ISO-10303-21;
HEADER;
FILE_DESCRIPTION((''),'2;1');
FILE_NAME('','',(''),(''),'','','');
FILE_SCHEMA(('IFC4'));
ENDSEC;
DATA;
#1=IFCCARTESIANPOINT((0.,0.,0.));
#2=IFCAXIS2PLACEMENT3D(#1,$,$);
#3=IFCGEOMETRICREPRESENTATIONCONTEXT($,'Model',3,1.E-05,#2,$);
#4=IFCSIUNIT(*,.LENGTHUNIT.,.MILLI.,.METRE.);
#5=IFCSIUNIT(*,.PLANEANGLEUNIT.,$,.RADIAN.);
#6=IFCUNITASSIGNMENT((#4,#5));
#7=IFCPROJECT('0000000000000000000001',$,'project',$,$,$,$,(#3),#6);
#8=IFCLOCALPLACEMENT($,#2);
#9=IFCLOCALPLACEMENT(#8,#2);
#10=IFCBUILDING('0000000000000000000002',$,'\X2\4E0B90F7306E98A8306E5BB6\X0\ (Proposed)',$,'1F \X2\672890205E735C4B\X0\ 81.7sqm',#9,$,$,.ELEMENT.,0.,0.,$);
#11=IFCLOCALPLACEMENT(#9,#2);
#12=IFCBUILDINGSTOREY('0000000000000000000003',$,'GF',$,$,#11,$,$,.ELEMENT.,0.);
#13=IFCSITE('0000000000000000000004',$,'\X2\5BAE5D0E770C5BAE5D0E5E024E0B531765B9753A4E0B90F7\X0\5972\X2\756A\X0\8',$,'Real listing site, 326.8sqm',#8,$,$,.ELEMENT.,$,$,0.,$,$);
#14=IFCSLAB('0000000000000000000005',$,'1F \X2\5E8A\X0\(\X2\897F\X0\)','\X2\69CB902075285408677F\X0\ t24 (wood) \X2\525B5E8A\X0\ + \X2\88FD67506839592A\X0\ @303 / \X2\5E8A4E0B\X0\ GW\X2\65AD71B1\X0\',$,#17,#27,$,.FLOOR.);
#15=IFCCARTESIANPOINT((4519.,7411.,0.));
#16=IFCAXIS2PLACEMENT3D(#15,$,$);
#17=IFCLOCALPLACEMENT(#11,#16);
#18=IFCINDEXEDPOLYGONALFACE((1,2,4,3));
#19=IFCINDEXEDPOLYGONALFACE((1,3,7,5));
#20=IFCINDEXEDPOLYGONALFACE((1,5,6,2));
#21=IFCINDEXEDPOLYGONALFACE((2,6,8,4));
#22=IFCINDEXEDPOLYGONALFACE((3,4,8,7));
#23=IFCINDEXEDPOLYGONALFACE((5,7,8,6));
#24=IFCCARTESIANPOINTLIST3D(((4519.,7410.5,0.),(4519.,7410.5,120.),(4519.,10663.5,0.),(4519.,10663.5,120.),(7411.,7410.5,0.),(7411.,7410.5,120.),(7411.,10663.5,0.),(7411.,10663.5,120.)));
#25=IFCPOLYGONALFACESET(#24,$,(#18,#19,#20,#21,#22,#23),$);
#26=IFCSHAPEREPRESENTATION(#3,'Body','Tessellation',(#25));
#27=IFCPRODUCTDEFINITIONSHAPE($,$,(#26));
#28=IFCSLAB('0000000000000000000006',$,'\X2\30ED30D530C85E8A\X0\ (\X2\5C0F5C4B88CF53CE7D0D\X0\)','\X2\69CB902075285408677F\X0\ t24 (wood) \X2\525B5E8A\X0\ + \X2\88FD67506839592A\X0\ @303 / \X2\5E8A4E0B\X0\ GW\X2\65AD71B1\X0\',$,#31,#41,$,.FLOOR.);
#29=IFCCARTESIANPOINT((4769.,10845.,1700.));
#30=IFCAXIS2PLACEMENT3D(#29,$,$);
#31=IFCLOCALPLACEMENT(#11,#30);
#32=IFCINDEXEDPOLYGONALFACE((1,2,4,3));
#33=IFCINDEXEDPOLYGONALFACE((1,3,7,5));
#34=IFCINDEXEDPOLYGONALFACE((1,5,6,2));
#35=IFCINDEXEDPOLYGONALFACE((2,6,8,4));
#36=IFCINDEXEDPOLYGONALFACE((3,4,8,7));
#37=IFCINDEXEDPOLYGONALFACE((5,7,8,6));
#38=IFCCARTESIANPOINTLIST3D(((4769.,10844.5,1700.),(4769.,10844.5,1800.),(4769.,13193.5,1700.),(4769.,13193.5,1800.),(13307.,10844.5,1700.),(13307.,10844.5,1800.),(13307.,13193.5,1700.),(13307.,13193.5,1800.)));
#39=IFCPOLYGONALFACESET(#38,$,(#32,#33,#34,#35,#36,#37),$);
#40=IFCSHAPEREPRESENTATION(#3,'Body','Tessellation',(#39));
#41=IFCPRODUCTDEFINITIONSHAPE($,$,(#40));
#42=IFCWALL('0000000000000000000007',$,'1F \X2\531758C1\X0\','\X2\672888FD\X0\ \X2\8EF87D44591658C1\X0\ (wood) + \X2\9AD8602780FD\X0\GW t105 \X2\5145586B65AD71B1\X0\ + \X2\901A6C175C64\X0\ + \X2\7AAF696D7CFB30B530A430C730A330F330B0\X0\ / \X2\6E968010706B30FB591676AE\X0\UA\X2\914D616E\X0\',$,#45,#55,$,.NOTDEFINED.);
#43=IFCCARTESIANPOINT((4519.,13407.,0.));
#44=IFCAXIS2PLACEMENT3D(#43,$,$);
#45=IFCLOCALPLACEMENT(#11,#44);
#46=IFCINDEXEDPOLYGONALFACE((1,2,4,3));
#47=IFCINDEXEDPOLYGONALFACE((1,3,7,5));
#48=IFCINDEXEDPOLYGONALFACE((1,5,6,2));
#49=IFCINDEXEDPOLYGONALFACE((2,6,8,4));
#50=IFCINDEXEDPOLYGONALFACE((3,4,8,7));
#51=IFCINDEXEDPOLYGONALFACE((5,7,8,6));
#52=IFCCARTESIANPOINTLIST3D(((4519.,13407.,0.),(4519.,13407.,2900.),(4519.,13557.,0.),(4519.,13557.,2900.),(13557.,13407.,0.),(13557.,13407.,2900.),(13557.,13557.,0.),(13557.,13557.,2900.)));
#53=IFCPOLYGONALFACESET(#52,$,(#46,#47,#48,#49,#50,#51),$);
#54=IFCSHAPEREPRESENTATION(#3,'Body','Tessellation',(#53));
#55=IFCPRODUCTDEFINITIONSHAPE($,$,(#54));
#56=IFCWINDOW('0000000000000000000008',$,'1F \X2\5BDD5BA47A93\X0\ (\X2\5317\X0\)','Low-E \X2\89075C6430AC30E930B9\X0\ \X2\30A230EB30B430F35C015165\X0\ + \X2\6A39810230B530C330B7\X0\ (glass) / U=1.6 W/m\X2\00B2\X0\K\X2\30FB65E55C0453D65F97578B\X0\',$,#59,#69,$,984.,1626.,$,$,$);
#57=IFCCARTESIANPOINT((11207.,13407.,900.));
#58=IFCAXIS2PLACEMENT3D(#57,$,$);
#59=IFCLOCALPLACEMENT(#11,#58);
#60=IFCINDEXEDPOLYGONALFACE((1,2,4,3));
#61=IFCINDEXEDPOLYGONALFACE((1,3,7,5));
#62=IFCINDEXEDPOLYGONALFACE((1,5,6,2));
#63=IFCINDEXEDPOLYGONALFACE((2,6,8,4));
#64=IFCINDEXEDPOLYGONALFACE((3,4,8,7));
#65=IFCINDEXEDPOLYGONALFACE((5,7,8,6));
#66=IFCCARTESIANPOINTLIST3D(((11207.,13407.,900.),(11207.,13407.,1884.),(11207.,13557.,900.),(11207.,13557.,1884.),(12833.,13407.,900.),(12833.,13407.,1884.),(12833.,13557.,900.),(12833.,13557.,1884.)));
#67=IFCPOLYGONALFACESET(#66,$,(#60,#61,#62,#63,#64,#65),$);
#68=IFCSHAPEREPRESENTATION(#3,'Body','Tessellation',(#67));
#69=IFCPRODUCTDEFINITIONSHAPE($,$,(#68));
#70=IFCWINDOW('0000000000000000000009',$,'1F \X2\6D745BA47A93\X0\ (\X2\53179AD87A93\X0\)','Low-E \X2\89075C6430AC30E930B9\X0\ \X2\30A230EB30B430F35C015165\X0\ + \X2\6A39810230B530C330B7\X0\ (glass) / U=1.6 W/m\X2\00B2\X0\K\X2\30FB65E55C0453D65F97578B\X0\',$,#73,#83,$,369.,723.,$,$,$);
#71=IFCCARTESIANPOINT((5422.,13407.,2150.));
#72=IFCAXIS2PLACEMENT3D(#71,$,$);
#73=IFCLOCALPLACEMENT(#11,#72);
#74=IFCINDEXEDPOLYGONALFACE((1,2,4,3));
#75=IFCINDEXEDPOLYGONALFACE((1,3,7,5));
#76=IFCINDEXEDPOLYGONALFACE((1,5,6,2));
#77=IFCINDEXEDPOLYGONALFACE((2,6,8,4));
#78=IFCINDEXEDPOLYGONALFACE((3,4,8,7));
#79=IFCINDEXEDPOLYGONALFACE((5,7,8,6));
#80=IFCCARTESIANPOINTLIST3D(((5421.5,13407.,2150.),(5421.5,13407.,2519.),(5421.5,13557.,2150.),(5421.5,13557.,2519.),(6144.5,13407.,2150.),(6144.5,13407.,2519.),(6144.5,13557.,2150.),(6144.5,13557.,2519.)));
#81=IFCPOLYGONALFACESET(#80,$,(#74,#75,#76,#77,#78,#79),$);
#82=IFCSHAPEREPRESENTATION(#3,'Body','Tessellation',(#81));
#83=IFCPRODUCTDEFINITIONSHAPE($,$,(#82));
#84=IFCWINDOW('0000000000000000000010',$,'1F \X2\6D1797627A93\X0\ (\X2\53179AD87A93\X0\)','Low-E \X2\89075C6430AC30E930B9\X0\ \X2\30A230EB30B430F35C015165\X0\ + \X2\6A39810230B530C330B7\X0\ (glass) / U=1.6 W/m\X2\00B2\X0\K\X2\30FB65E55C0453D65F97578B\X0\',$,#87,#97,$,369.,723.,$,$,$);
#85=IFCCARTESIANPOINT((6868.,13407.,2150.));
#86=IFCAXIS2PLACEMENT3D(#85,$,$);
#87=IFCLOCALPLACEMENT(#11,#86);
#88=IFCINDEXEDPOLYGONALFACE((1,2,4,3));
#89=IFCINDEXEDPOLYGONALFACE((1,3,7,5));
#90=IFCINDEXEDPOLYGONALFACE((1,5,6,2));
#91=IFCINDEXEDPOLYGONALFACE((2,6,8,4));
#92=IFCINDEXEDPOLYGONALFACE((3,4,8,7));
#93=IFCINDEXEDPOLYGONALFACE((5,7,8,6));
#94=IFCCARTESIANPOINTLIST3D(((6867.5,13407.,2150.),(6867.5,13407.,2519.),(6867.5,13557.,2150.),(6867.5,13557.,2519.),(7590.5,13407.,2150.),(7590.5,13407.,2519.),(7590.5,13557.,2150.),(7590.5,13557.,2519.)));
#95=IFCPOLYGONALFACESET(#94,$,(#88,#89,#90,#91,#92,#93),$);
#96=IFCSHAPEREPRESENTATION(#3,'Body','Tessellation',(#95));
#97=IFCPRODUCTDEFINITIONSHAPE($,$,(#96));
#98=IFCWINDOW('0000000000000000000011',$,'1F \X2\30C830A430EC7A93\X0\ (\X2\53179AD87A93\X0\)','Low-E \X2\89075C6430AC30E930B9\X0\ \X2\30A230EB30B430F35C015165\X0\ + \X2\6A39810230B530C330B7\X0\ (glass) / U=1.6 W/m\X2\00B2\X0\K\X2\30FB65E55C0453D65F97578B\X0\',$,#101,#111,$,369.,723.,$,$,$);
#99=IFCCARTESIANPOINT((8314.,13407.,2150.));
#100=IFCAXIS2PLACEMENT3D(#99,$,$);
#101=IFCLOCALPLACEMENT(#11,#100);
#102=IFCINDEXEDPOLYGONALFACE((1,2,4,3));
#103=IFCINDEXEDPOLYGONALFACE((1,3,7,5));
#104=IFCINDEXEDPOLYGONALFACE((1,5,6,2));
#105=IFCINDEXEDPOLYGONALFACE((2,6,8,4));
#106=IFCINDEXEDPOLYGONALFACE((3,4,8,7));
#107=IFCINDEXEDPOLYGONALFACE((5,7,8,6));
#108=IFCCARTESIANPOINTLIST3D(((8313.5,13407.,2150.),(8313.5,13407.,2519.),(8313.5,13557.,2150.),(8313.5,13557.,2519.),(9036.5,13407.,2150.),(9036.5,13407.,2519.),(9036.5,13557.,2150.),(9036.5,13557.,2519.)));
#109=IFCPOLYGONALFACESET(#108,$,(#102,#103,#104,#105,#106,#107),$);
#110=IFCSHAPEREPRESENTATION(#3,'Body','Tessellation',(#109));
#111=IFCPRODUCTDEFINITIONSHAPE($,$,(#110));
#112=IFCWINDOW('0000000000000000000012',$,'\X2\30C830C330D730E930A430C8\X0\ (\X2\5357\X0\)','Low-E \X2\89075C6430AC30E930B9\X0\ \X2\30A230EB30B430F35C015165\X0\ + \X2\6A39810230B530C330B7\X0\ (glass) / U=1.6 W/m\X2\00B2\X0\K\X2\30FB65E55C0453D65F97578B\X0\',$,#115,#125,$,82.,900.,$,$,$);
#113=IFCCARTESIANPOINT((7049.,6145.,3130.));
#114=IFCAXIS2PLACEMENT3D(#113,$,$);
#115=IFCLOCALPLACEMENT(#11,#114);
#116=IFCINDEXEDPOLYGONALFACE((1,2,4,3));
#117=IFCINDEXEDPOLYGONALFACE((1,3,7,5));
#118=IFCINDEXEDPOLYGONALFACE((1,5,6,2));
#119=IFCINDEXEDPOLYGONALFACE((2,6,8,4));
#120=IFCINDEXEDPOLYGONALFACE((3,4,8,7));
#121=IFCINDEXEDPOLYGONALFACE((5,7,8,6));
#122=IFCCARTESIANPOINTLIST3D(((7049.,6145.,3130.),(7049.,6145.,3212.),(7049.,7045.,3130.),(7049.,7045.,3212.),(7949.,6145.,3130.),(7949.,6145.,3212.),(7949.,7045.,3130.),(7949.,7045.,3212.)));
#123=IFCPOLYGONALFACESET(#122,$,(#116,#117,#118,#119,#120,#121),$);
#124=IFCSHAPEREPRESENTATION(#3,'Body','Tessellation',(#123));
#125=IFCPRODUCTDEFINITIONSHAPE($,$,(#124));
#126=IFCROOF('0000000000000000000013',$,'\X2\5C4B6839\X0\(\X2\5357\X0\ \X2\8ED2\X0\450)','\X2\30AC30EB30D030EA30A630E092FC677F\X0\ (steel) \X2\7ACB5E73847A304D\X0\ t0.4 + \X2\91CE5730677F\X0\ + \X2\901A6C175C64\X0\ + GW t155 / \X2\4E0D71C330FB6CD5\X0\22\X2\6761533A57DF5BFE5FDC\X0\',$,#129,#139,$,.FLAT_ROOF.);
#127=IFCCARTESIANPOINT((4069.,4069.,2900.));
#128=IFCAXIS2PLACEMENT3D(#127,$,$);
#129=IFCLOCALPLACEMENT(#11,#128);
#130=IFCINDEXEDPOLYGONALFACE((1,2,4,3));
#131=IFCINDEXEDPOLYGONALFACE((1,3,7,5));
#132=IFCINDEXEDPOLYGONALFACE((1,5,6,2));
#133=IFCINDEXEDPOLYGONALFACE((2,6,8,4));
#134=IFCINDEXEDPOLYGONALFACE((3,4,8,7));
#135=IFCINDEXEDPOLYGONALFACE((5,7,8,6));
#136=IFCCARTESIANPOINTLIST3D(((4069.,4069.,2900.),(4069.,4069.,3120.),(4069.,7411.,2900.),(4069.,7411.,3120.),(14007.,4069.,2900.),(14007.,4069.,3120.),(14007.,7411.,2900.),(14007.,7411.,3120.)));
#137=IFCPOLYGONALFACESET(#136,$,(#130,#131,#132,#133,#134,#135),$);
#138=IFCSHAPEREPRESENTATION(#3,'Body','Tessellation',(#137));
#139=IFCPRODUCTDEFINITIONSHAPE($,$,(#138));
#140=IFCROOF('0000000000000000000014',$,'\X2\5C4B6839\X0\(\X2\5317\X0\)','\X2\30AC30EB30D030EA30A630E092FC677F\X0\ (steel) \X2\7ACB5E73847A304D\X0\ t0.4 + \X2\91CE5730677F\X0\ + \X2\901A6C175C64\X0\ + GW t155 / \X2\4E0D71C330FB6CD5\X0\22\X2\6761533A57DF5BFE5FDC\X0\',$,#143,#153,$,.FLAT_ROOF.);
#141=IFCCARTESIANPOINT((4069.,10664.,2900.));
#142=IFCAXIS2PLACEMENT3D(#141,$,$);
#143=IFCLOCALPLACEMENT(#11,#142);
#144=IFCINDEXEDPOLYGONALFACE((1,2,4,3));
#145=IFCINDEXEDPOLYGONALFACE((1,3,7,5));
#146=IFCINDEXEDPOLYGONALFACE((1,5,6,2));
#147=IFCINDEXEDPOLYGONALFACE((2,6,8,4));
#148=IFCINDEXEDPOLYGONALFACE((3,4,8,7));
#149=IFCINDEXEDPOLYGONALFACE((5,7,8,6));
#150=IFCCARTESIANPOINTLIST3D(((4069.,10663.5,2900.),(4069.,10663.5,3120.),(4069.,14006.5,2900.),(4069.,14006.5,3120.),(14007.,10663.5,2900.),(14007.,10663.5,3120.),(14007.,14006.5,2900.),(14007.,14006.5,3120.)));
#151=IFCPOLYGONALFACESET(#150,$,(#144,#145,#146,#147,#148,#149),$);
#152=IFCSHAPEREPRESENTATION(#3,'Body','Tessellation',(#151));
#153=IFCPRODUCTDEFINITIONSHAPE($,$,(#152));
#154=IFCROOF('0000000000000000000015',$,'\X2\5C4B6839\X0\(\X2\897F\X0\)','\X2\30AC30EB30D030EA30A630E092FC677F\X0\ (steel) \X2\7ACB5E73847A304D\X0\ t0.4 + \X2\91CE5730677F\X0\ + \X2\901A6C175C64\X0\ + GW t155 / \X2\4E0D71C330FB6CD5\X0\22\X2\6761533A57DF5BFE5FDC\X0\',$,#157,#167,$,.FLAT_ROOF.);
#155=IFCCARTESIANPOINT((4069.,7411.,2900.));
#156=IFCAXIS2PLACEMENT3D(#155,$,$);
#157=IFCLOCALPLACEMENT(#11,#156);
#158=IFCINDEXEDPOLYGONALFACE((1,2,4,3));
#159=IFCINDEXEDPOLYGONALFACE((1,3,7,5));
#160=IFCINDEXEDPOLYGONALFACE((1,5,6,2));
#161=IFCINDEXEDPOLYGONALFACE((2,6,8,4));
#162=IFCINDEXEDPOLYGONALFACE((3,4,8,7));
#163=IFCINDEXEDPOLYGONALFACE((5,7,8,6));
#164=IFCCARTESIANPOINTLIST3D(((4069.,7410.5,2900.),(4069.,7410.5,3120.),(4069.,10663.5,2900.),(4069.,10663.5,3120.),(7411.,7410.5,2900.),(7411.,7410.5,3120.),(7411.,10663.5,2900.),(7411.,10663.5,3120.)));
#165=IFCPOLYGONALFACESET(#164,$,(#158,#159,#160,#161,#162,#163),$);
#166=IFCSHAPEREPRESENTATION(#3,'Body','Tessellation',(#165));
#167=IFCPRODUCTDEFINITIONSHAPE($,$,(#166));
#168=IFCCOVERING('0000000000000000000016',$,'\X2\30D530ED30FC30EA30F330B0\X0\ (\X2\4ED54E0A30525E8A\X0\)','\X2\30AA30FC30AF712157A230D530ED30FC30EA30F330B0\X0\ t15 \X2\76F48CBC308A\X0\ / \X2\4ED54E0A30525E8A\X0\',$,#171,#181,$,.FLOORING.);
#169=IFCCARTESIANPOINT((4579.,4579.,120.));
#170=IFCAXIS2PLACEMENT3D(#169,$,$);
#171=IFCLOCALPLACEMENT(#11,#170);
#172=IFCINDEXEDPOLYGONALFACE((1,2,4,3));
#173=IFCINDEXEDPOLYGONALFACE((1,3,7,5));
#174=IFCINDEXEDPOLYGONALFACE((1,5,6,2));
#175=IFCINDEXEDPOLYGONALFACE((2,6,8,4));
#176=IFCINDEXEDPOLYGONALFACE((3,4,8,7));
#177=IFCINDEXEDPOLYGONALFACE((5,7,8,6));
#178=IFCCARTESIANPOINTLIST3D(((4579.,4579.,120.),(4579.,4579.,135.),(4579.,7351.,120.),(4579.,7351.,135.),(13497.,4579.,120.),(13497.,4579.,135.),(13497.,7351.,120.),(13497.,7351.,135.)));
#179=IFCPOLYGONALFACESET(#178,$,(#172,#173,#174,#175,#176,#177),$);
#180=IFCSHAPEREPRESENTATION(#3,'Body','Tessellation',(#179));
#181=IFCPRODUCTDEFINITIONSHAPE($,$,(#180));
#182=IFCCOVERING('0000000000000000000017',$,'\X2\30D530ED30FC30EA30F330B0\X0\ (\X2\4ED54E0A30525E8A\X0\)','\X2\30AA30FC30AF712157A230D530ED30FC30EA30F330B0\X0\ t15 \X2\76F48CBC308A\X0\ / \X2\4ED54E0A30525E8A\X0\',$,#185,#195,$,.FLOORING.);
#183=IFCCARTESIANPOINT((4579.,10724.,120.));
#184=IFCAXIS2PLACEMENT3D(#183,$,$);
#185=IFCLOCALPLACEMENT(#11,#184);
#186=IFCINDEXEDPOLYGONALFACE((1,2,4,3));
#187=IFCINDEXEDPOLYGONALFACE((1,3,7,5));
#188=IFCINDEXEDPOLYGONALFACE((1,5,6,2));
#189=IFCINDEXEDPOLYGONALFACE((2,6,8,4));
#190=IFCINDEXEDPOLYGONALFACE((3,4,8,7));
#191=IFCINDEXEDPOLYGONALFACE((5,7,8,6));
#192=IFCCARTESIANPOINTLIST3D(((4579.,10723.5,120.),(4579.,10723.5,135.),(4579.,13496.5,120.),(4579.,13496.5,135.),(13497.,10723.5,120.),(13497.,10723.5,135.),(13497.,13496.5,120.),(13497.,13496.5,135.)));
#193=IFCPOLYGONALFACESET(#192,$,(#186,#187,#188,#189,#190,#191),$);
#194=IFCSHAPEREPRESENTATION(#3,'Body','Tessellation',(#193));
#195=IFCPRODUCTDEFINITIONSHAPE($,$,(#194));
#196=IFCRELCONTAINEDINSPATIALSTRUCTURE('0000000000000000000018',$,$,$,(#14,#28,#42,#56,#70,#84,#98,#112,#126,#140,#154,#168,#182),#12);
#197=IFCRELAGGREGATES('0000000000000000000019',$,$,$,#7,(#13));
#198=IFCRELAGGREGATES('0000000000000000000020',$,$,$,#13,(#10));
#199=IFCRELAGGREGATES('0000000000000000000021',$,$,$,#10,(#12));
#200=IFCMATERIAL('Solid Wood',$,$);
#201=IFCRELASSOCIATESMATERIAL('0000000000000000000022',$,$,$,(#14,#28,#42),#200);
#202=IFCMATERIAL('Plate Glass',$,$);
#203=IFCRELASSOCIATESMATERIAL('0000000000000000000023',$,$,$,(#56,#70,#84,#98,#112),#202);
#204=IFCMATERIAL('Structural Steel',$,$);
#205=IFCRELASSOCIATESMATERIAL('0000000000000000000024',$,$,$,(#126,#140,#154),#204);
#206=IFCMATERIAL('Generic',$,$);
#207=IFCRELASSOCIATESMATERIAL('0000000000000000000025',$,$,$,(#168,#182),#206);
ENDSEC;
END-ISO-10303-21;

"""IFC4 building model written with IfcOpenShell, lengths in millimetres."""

from ifc_helpers import new_model, si_unit, frame, frame_2d, origin, place, context, project, spatial, rectangle, extrude, material, element, fill, save


model = new_model("IFC4")

# Units and contexts
model_context = context("Model", 3, precision=1e-05, world=origin())
ifc_project = project(units=[si_unit("LENGTHUNIT", "METRE", prefix="MILLI"), si_unit("PLANEANGLEUNIT", "RADIAN")], contexts=[model_context])

# Site, building, storey
site_placement = place(None, origin())
site = spatial("IfcSite", under=ifc_project, at=site_placement, Name="宮崎県宮崎市下北方町下郷5972番8", ObjectType="Real listing site, 326.8sqm", CompositionType="ELEMENT", RefElevation=0.0)
building_placement = place(site_placement, origin())
building = spatial("IfcBuilding", under=site, at=building_placement, Name="下郷の風の家 (Proposed)", ObjectType="1F 木造平屋 81.7sqm", CompositionType="ELEMENT", ElevationOfRefHeight=0.0, ElevationOfTerrain=0.0)
storey_placement = place(building_placement, origin())
storey = spatial("IfcBuildingStorey", under=building, at=storey_placement, Name="GF", CompositionType="ELEMENT", Elevation=0.0)

# Slabs
ifc_material_1 = material(Name="Solid Wood")
slab_1_placement = place(storey_placement, frame((4519.0, 7411.0, 0.0)))
element("IfcSlab", 1, at=slab_1_placement, inside=storey, material=ifc_material_1, Name="1F 床(西)", Description="構造用合板 t24 (wood) 剛床 + 製材根太 @303 / 床下 GW断熱", PredefinedType="FLOOR", context=model_context, shape_type="SweptSolid", body=[
    extrude(rectangle(XDim=2892.0, YDim=3253.0, at=frame_2d((1446.0, 1626.0))), frame((4519.0, 7411.0, 0.0)), (0.0, 0.0, 1.0), 120.0),
])
slab_2_placement = place(storey_placement, frame((4769.0, 10845.0, 1700.0)))
element("IfcSlab", 2, at=slab_2_placement, inside=storey, material=ifc_material_1, Name="ロフト床 (小屋裏収納)", Description="構造用合板 t24 (wood) 剛床 + 製材根太 @303 / 床下 GW断熱", PredefinedType="FLOOR", context=model_context, shape_type="SweptSolid", body=[
    extrude(rectangle(XDim=8538.0, YDim=2349.0, at=frame_2d((4269.0, 1174.0))), frame((4769.0, 10845.0, 1700.0)), (0.0, 0.0, 1.0), 100.0),
])

# Shared definitions
ifc_material_2 = material(Name="Plate Glass")

# Wall, openings, windows
wall_1_placement = place(storey_placement, frame((4519.0, 13407.0, 0.0)))
wall_1 = element("IfcWall", 3, at=wall_1_placement, inside=storey, material=ifc_material_1, Name="1F 北壁", Description="木製 軸組外壁 (wood) + 高性能GW t105 充填断熱 + 通気層 + 窯業系サイディング / 準耐火・外皮UA配慮", PredefinedType="NOTDEFINED", context=model_context, shape_type="SweptSolid", body=[
    extrude(rectangle(XDim=9038.0, YDim=150.0, at=frame_2d((4519.0, 75.0))), frame((4519.0, 13407.0, 0.0)), (0.0, 0.0, 1.0), 2900.0),
])
opening_1_placement = place(storey_placement, frame((11207.0, 13407.0, 900.0)))
opening_1 = element("IfcOpeningElement", 4, at=opening_1_placement, cuts=wall_1, PredefinedType="NOTDEFINED", context=model_context, shape_type="SweptSolid", body=[
    extrude(rectangle(XDim=1626.0, YDim=150.0, at=frame_2d((813.0, 75.0))), frame((11207.0, 13407.0, 900.0)), (0.0, 0.0, 1.0), 984.0),
])
opening_2_placement = place(storey_placement, frame((5422.0, 13407.0, 2150.0)))
opening_2 = element("IfcOpeningElement", 5, at=opening_2_placement, cuts=wall_1, PredefinedType="NOTDEFINED", context=model_context, shape_type="SweptSolid", body=[
    extrude(rectangle(XDim=723.0, YDim=150.0, at=frame_2d((361.0, 75.0))), frame((5422.0, 13407.0, 2150.0)), (0.0, 0.0, 1.0), 369.0),
])
opening_3_placement = place(storey_placement, frame((6868.0, 13407.0, 2150.0)))
opening_3 = element("IfcOpeningElement", 6, at=opening_3_placement, cuts=wall_1, PredefinedType="NOTDEFINED", context=model_context, shape_type="SweptSolid", body=[
    extrude(rectangle(XDim=723.0, YDim=150.0, at=frame_2d((361.0, 75.0))), frame((6868.0, 13407.0, 2150.0)), (0.0, 0.0, 1.0), 369.0),
])
opening_4_placement = place(storey_placement, frame((8314.0, 13407.0, 2150.0)))
opening_4 = element("IfcOpeningElement", 7, at=opening_4_placement, cuts=wall_1, PredefinedType="NOTDEFINED", context=model_context, shape_type="SweptSolid", body=[
    extrude(rectangle(XDim=723.0, YDim=150.0, at=frame_2d((361.0, 75.0))), frame((8314.0, 13407.0, 2150.0)), (0.0, 0.0, 1.0), 369.0),
])
window_1_placement = place(storey_placement, frame((11207.0, 13407.0, 900.0)))
window_1 = element("IfcWindow", 8, at=window_1_placement, inside=storey, material=ifc_material_2, Name="1F 寝室窓 (北)", Description="Low-E 複層ガラス アルゴン封入 + 樹脂サッシ (glass) / U=1.6 W/m²K・日射取得型", OverallHeight=984.0, OverallWidth=1626.0, context=model_context, shape_type="SweptSolid", body=[
    extrude(rectangle(XDim=1626.0, YDim=150.0, at=frame_2d((813.0, 75.0))), frame((11207.0, 13407.0, 900.0)), (0.0, 0.0, 1.0), 984.0),
])
fill(opening_1, window_1)
window_2_placement = place(storey_placement, frame((5422.0, 13407.0, 2150.0)))
window_2 = element("IfcWindow", 9, at=window_2_placement, inside=storey, material=ifc_material_2, Name="1F 浴室窓 (北高窓)", Description="Low-E 複層ガラス アルゴン封入 + 樹脂サッシ (glass) / U=1.6 W/m²K・日射取得型", OverallHeight=369.0, OverallWidth=723.0, context=model_context, shape_type="SweptSolid", body=[
    extrude(rectangle(XDim=723.0, YDim=150.0, at=frame_2d((361.0, 75.0))), frame((5422.0, 13407.0, 2150.0)), (0.0, 0.0, 1.0), 369.0),
])
fill(opening_2, window_2)
window_3_placement = place(storey_placement, frame((6868.0, 13407.0, 2150.0)))
window_3 = element("IfcWindow", 10, at=window_3_placement, inside=storey, material=ifc_material_2, Name="1F 洗面窓 (北高窓)", Description="Low-E 複層ガラス アルゴン封入 + 樹脂サッシ (glass) / U=1.6 W/m²K・日射取得型", OverallHeight=369.0, OverallWidth=723.0, context=model_context, shape_type="SweptSolid", body=[
    extrude(rectangle(XDim=723.0, YDim=150.0, at=frame_2d((361.0, 75.0))), frame((6868.0, 13407.0, 2150.0)), (0.0, 0.0, 1.0), 369.0),
])
fill(opening_3, window_3)
window_4_placement = place(storey_placement, frame((8314.0, 13407.0, 2150.0)))
window_4 = element("IfcWindow", 11, at=window_4_placement, inside=storey, material=ifc_material_2, Name="1F トイレ窓 (北高窓)", Description="Low-E 複層ガラス アルゴン封入 + 樹脂サッシ (glass) / U=1.6 W/m²K・日射取得型", OverallHeight=369.0, OverallWidth=723.0, context=model_context, shape_type="SweptSolid", body=[
    extrude(rectangle(XDim=723.0, YDim=150.0, at=frame_2d((361.0, 75.0))), frame((8314.0, 13407.0, 2150.0)), (0.0, 0.0, 1.0), 369.0),
])
fill(opening_4, window_4)

# Window
window_5_placement = place(storey_placement, frame((7049.0, 6145.0, 3130.0)))
element("IfcWindow", 12, at=window_5_placement, inside=storey, material=ifc_material_2, Name="トップライト (南)", Description="Low-E 複層ガラス アルゴン封入 + 樹脂サッシ (glass) / U=1.6 W/m²K・日射取得型", OverallHeight=82.0, OverallWidth=900.0, context=model_context, shape_type="SweptSolid", body=[
    extrude(rectangle(XDim=900.0, YDim=900.0, at=frame_2d((450.0, 450.0))), frame((7049.0, 6145.0, 3130.0)), (0.0, 0.0, 1.0), 82.0),
])

# Roofs
ifc_material_3 = material(Name="Structural Steel")
roof_1_placement = place(storey_placement, frame((4069.0, 4069.0, 2900.0)))
element("IfcRoof", 13, at=roof_1_placement, inside=storey, material=ifc_material_3, Name="屋根(南 軒450)", Description="ガルバリウム鋼板 (steel) 立平葺き t0.4 + 野地板 + 通気層 + GW t155 / 不燃・法22条区域対応", PredefinedType="FLAT_ROOF", context=model_context, shape_type="SweptSolid", body=[
    extrude(rectangle(XDim=9938.0, YDim=3342.0, at=frame_2d((4969.0, 1671.0))), frame((4069.0, 4069.0, 2900.0)), (0.0, 0.0, 1.0), 220.0),
])
roof_2_placement = place(storey_placement, frame((4069.0, 10664.0, 2900.0)))
element("IfcRoof", 14, at=roof_2_placement, inside=storey, material=ifc_material_3, Name="屋根(北)", Description="ガルバリウム鋼板 (steel) 立平葺き t0.4 + 野地板 + 通気層 + GW t155 / 不燃・法22条区域対応", PredefinedType="FLAT_ROOF", context=model_context, shape_type="SweptSolid", body=[
    extrude(rectangle(XDim=9938.0, YDim=3343.0, at=frame_2d((4969.0, 1671.0))), frame((4069.0, 10664.0, 2900.0)), (0.0, 0.0, 1.0), 220.0),
])
roof_3_placement = place(storey_placement, frame((4069.0, 7411.0, 2900.0)))
element("IfcRoof", 15, at=roof_3_placement, inside=storey, material=ifc_material_3, Name="屋根(西)", Description="ガルバリウム鋼板 (steel) 立平葺き t0.4 + 野地板 + 通気層 + GW t155 / 不燃・法22条区域対応", PredefinedType="FLAT_ROOF", context=model_context, shape_type="SweptSolid", body=[
    extrude(rectangle(XDim=3342.0, YDim=3253.0, at=frame_2d((1671.0, 1626.0))), frame((4069.0, 7411.0, 2900.0)), (0.0, 0.0, 1.0), 220.0),
])

# Coverings
ifc_material_4 = material(Name="Generic")
covering_1_placement = place(storey_placement, frame((4579.0, 4579.0, 120.0)))
element("IfcCovering", 16, at=covering_1_placement, inside=storey, material=ifc_material_4, Name="フローリング (仕上げ床)", Description="オーク無垢フローリング t15 直貼り / 仕上げ床", PredefinedType="FLOORING", context=model_context, shape_type="SweptSolid", body=[
    extrude(rectangle(XDim=8918.0, YDim=2772.0, at=frame_2d((4459.0, 1386.0))), frame((4579.0, 4579.0, 120.0)), (0.0, 0.0, 1.0), 15.0),
])
covering_2_placement = place(storey_placement, frame((4579.0, 10724.0, 120.0)))
element("IfcCovering", 17, at=covering_2_placement, inside=storey, material=ifc_material_4, Name="フローリング (仕上げ床)", Description="オーク無垢フローリング t15 直貼り / 仕上げ床", PredefinedType="FLOORING", context=model_context, shape_type="SweptSolid", body=[
    extrude(rectangle(XDim=8918.0, YDim=2773.0, at=frame_2d((4459.0, 1386.0))), frame((4579.0, 10724.0, 120.0)), (0.0, 0.0, 1.0), 15.0),
])

save(model, "model.ifc")
